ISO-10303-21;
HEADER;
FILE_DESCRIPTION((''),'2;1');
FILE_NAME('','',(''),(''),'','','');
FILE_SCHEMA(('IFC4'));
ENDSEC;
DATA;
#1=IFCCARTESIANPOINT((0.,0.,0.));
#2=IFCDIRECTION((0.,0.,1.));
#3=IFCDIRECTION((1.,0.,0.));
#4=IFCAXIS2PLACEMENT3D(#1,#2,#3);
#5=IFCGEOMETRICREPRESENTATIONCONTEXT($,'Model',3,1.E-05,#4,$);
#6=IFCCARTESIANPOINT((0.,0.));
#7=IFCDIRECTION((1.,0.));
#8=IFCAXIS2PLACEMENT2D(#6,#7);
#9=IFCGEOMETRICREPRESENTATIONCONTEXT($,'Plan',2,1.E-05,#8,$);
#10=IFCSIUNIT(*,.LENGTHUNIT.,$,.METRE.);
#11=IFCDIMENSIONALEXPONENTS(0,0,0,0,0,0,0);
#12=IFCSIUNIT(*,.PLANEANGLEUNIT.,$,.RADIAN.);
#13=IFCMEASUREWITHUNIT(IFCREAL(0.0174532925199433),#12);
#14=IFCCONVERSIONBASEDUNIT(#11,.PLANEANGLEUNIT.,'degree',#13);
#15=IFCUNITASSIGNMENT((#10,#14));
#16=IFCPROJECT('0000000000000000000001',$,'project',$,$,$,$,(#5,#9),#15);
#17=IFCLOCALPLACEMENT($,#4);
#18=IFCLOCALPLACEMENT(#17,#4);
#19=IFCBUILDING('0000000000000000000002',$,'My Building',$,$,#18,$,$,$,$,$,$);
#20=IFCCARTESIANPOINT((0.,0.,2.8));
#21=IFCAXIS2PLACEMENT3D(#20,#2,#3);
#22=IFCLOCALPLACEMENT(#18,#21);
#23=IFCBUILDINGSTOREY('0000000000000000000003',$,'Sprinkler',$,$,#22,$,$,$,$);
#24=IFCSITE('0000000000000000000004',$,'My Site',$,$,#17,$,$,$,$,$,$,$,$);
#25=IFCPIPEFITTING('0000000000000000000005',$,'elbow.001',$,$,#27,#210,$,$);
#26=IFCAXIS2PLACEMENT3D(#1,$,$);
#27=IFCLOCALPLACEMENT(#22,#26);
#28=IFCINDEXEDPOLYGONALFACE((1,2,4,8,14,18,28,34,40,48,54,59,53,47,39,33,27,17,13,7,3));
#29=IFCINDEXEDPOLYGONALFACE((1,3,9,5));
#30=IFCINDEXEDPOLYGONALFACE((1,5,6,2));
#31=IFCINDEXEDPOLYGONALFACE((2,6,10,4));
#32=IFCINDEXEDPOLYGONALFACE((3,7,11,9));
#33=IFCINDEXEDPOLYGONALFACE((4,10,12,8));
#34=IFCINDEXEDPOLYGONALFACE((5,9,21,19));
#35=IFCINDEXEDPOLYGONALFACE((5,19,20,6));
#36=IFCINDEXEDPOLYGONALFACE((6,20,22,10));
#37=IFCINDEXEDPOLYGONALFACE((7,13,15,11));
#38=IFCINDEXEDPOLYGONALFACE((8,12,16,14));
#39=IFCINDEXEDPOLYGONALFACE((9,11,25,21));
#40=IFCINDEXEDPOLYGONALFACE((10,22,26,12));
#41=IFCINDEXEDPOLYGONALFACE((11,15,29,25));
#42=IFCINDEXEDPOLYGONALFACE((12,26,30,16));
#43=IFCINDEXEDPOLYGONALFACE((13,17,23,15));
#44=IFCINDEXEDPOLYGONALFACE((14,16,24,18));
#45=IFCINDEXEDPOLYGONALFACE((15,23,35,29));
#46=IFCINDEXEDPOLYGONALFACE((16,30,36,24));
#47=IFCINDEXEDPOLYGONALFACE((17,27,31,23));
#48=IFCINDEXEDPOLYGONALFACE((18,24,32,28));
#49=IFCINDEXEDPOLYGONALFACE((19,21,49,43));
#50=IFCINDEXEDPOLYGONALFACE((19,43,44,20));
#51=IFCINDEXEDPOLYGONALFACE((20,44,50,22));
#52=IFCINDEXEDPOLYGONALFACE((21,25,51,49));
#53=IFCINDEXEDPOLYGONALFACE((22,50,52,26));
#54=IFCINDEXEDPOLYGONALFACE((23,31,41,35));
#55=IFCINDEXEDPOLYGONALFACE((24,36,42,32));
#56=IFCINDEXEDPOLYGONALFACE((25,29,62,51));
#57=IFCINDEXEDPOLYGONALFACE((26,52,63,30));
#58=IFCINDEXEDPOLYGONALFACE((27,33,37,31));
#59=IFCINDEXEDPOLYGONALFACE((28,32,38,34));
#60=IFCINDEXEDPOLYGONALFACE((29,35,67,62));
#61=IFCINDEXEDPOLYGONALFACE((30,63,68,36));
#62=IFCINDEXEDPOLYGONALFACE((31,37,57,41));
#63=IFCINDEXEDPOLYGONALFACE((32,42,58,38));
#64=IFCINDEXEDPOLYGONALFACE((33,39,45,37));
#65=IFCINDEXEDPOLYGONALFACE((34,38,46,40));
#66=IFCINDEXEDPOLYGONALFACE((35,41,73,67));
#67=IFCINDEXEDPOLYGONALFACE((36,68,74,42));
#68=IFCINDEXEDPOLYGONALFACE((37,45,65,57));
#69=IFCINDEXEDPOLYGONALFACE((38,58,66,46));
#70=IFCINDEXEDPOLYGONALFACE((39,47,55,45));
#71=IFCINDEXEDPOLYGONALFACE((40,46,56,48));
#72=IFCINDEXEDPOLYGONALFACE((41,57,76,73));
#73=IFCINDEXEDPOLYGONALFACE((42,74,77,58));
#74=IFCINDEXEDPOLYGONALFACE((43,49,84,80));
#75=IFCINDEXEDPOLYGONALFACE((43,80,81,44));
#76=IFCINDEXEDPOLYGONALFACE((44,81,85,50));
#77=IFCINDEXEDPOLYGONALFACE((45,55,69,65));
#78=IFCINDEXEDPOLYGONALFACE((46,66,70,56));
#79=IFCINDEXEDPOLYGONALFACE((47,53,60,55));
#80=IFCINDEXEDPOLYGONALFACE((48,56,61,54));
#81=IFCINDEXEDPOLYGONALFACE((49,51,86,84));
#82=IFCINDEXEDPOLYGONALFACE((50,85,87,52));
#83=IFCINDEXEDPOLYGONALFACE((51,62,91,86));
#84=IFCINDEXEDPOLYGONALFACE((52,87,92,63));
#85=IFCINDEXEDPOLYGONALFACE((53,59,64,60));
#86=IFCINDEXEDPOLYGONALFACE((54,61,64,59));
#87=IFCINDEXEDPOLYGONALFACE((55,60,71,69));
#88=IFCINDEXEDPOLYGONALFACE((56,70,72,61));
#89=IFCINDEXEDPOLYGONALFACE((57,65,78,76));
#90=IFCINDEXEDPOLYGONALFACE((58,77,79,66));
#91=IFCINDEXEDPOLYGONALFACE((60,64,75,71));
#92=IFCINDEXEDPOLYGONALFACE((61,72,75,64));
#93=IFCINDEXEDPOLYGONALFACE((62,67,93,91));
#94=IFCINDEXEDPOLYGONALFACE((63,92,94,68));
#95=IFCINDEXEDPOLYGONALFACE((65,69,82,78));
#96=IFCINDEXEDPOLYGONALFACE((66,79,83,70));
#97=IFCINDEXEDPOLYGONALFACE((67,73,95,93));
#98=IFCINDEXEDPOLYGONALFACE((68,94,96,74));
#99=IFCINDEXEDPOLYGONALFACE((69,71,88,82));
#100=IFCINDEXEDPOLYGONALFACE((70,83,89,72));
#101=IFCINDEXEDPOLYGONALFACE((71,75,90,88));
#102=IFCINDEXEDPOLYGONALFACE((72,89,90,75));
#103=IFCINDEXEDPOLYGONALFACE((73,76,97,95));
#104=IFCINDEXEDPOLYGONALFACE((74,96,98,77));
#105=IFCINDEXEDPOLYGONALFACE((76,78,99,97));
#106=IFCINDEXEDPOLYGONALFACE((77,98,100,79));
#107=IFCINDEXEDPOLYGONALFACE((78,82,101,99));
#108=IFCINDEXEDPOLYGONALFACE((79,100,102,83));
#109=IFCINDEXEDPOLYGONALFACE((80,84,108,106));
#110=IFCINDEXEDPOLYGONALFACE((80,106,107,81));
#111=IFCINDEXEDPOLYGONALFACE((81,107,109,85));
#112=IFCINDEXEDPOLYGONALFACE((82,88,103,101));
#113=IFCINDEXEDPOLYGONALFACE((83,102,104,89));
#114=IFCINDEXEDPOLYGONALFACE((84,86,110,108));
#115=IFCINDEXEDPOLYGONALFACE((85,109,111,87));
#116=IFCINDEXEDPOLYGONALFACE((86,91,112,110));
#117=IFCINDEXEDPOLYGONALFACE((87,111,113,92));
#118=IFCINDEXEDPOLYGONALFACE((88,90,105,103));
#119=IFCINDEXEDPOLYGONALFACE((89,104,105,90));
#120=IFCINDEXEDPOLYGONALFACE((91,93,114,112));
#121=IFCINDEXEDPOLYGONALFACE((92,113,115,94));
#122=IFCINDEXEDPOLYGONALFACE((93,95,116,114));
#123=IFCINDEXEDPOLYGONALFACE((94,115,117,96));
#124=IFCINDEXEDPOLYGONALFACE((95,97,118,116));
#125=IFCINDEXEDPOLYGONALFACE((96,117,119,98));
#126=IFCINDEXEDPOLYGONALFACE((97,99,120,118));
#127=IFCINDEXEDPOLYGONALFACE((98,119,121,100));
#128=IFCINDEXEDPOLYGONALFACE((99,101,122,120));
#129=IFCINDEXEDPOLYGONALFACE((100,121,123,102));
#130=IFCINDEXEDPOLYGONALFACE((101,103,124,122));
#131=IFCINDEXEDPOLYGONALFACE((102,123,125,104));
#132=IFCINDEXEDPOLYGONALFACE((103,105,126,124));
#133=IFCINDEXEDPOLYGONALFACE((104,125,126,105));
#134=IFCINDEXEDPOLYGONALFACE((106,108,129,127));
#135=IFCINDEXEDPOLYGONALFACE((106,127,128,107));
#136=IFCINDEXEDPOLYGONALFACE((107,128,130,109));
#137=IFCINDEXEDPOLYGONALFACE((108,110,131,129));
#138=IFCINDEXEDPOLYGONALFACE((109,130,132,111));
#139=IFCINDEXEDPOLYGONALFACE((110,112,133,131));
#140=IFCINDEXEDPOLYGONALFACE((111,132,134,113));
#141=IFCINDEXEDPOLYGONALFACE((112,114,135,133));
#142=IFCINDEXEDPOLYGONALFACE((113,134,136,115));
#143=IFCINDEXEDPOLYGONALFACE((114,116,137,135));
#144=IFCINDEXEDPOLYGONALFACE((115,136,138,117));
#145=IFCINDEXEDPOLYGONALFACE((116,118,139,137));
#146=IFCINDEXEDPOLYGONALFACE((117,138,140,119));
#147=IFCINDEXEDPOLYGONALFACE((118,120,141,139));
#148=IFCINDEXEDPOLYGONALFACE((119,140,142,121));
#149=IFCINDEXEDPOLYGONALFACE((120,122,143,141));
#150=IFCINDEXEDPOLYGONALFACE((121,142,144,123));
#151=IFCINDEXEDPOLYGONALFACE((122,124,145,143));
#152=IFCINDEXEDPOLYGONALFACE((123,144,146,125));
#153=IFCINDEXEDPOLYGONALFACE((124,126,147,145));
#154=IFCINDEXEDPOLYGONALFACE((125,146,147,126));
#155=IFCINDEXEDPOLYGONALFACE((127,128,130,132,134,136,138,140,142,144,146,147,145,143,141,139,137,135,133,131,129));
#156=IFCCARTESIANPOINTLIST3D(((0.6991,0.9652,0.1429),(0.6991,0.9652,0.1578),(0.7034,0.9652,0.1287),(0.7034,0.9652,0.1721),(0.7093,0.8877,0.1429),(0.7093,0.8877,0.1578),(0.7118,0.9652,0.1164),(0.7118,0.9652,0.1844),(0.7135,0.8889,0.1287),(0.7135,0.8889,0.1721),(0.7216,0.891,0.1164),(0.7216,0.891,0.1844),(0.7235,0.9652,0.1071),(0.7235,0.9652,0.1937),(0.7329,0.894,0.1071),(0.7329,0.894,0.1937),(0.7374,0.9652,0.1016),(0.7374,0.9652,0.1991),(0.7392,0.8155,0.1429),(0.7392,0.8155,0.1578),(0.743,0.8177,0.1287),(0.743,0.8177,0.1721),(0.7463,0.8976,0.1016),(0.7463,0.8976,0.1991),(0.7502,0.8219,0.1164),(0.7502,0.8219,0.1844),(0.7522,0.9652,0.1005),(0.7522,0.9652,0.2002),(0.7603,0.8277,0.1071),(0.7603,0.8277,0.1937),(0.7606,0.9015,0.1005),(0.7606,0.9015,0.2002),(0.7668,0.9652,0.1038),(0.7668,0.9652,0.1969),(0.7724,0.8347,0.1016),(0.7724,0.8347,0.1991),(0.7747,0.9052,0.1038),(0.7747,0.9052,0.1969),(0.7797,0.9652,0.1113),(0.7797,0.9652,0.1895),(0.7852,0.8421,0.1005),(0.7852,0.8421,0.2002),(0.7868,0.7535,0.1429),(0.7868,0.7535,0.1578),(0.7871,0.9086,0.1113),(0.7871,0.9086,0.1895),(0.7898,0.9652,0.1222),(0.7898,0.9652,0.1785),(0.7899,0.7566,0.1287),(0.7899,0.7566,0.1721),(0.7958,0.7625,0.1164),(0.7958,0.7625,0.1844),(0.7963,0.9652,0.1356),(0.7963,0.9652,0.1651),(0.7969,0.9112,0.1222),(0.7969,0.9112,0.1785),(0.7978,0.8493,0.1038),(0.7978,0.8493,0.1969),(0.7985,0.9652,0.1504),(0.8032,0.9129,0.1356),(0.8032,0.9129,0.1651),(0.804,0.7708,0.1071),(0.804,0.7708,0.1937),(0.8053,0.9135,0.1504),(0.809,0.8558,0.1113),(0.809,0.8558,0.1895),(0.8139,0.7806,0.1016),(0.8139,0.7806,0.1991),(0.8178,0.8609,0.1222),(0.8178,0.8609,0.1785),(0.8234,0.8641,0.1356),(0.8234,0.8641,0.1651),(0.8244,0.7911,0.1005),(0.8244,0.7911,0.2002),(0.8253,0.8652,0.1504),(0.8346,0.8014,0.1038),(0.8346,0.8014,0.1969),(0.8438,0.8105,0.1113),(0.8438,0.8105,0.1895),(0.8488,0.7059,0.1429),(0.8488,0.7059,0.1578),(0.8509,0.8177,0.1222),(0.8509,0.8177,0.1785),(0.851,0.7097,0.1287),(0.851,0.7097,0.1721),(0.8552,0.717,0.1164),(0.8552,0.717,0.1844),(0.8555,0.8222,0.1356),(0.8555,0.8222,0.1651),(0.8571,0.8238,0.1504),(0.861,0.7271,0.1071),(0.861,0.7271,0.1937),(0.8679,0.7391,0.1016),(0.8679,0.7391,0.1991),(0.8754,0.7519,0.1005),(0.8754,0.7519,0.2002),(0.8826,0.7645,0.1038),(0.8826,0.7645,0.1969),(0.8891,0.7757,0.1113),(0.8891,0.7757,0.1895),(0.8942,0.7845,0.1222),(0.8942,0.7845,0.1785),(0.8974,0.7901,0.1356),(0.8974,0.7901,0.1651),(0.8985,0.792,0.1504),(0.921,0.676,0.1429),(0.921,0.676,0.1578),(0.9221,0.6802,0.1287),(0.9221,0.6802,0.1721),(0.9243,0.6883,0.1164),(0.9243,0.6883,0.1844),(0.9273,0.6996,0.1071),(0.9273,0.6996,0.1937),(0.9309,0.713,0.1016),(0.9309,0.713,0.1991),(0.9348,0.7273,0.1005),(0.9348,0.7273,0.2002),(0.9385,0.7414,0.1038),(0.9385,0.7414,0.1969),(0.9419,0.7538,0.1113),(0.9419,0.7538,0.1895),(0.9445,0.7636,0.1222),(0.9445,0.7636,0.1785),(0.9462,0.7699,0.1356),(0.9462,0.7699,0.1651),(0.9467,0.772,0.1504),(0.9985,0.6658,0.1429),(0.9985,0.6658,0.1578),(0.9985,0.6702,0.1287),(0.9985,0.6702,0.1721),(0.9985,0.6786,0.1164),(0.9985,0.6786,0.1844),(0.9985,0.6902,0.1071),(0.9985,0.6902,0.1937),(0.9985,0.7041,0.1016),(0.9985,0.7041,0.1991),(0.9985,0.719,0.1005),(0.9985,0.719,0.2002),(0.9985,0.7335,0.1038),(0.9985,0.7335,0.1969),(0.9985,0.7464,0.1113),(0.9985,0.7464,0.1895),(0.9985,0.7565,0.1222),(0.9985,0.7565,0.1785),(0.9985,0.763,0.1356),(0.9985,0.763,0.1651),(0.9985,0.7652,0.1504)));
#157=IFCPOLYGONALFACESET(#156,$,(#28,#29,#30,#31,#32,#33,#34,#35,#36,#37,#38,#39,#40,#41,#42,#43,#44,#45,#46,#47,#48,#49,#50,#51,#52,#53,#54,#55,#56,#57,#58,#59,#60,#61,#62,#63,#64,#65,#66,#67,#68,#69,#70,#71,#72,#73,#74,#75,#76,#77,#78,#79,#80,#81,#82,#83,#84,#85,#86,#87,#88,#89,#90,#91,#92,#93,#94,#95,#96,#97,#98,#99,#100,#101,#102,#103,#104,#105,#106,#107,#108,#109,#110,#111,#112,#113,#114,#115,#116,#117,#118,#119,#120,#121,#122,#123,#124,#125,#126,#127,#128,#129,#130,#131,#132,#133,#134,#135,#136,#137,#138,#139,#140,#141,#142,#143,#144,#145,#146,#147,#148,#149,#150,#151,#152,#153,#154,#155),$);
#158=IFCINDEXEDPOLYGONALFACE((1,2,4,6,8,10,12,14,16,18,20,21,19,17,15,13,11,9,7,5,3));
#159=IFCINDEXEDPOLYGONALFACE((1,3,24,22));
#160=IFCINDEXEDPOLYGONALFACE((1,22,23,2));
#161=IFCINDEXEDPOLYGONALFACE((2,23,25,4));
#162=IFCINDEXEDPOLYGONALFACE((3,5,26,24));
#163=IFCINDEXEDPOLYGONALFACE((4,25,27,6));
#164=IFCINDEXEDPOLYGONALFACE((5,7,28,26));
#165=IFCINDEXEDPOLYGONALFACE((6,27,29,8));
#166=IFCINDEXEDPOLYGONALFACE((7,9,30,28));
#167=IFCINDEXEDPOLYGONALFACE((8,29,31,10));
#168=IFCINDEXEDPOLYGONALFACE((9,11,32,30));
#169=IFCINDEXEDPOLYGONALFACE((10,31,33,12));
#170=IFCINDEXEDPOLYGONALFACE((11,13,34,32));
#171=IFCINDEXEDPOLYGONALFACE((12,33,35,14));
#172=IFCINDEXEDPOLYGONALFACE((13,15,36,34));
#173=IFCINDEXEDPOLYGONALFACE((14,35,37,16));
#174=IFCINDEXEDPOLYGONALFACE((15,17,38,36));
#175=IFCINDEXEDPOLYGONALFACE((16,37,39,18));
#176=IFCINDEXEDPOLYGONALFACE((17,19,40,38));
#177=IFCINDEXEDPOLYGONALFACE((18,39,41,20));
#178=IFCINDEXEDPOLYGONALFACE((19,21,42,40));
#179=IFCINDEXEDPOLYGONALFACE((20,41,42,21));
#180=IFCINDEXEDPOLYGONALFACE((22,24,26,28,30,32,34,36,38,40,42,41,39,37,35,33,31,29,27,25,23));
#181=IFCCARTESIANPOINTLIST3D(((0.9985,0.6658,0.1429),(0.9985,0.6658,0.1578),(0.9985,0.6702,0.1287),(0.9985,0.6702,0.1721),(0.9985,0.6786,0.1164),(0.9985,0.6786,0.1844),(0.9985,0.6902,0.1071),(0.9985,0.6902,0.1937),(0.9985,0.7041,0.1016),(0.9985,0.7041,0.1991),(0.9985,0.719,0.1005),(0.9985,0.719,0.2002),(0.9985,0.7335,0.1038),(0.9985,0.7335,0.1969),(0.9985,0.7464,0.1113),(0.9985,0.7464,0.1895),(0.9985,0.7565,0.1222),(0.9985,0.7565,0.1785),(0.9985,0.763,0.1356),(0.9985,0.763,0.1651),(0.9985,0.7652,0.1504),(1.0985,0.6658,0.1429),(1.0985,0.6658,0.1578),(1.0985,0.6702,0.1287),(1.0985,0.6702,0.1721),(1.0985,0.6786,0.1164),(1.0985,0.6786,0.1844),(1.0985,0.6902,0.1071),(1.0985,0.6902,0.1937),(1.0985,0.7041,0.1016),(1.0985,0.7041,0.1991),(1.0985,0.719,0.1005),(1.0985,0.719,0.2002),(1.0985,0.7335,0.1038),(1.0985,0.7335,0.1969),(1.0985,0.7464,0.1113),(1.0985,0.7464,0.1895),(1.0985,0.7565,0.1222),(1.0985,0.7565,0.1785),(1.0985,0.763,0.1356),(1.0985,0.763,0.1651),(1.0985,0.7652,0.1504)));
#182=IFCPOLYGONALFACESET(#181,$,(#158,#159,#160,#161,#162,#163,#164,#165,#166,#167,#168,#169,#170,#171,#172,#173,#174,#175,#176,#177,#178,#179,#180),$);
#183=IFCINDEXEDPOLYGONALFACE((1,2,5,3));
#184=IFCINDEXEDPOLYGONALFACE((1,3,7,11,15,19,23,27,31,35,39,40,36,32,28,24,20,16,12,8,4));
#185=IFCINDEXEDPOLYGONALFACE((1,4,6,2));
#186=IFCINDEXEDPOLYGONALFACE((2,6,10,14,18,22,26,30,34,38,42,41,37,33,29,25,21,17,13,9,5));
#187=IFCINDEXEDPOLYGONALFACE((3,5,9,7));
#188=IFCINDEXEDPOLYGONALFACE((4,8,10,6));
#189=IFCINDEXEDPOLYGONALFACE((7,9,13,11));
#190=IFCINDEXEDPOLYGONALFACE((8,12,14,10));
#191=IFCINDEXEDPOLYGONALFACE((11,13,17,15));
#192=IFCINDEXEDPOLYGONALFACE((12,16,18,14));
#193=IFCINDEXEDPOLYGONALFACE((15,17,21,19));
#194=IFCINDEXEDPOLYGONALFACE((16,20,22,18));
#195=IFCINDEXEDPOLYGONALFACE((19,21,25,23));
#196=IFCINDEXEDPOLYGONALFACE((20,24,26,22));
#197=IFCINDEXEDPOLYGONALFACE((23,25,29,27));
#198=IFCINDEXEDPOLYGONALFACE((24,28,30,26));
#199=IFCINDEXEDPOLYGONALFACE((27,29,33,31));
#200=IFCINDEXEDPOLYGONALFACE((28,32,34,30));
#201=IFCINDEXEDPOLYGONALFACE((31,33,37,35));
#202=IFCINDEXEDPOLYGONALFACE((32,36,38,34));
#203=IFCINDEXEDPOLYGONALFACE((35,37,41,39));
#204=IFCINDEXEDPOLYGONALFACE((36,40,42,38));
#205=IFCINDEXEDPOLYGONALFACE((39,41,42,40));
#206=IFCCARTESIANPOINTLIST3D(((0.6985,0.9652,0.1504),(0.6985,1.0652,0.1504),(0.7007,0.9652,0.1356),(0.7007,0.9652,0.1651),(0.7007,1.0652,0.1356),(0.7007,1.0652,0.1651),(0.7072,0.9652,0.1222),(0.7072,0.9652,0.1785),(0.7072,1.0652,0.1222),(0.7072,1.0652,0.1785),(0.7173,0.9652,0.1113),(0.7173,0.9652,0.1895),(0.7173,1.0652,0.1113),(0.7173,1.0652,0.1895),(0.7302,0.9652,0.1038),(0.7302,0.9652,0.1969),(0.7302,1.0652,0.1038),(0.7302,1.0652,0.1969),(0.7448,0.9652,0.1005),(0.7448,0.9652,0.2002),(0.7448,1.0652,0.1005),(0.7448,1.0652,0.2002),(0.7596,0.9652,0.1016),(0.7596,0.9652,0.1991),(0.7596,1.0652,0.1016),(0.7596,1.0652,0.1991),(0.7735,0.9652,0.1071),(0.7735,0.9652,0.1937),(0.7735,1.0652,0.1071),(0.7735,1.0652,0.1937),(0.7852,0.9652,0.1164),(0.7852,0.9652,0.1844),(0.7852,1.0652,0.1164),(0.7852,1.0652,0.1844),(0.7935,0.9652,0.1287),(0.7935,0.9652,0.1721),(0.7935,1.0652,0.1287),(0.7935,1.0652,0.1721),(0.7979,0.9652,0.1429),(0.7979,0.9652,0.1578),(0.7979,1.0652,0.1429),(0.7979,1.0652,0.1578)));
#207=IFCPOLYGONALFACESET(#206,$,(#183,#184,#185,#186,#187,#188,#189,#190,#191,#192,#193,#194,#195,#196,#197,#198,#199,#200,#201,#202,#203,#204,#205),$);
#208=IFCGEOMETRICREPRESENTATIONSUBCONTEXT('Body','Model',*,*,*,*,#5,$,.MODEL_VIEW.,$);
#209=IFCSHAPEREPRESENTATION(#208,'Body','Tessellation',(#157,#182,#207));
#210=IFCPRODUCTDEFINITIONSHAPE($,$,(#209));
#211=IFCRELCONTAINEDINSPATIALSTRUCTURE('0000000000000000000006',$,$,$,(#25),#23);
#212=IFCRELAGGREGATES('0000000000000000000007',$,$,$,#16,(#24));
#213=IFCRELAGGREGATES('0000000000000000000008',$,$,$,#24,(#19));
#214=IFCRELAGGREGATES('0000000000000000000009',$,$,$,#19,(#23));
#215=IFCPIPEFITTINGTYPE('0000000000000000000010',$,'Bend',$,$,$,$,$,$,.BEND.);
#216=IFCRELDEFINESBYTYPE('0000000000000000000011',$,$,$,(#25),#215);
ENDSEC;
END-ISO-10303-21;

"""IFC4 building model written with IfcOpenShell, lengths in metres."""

from ifc_helpers import new_model, entity, si_unit, converted_unit, frame, origin_with_axes, origin_2d_with_axis, place, context, subcontext, project, spatial, circle, extrude, source, transform, mapped, type_object, type_shapes, element, save


model = new_model("IFC4")

# Units and contexts
model_context = context("Model", 3, precision=1e-05, world=origin_with_axes())
plan_context = context("Plan", 2, precision=1e-05, world=origin_2d_with_axis())
body_context = subcontext(model_context, "Body", "Model", "MODEL_VIEW")
ifc_project = project(units=[si_unit("LENGTHUNIT", "METRE"), converted_unit("PLANEANGLEUNIT", "degree", entity("IfcReal", 0.0174532925199433), si_unit("PLANEANGLEUNIT", "RADIAN"), dimensions=[0, 0, 0, 0, 0, 0, 0])], contexts=[model_context, plan_context])

# Site, building, storey
site_placement = place(None, origin_with_axes())
site = spatial("IfcSite", under=ifc_project, at=site_placement, Name="My Site")
building_placement = place(site_placement, origin_with_axes())
building = spatial("IfcBuilding", under=site, at=building_placement, Name="My Building")
storey_placement = place(building_placement, frame((0.0, 0.0, 2.8), z_axis=(0.0, 0.0, 1.0), x_axis=(1.0, 0.0, 0.0)))
storey = spatial("IfcBuildingStorey", under=building, at=storey_placement, Name="Sprinkler")

# Pipe fitting
pipe_fitting_type_1 = type_object("IfcPipeFittingType", Name="Bend", PredefinedType="BEND")
shared_shape_1 = source(origin_with_axes(), body_context, "Body", "SolidModel", [
    entity("IfcSweptDiskSolid", entity("IfcIndexedPolyCurve", entity("IfcCartesianPointList3D", [[0.0, 0.0, 0.1], [0.0732, 0.0, 0.2768], [0.25, 0.0, 0.35]]), [entity("IfcArcIndex", [1, 2, 3])]), 0.05),
    extrude(circle(Radius=0.05), origin_with_axes(), (0.0, 0.0, 1.0), 0.1),
    extrude(circle(Radius=0.05), frame((0.25, 0.0, 0.35), z_axis=(1.0, 0.0, 0.000001), x_axis=(-0.000001, 0.0, 1.0)), (0.0, 0.0, 1.0), 0.1),
])
type_shapes(pipe_fitting_type_1, [shared_shape_1])
for number, where, z_axis, x_axis, name in (
    (1, (1.0985, 0.7152, 0.1504), (-1.0, 0.0, 0.0), (0.0, 1.0, 0.0), "elbow.001"),
):
    element("IfcPipeFitting", number, at=place(storey_placement, frame(where, z_axis=z_axis, x_axis=x_axis)), inside=storey, type_object=pipe_fitting_type_1, Name=name, context=body_context, shape_type="MappedRepresentation", body=[
        mapped(shared_shape_1, transform((0.0, 0.0, 0.0), x_axis=(1.0, 0.0, 0.0), y_axis=(0.0, 1.0, 0.0), z_axis=(0.0, 0.0, 1.0), scale=1.0)),
    ])

save(model, "model.ifc")
